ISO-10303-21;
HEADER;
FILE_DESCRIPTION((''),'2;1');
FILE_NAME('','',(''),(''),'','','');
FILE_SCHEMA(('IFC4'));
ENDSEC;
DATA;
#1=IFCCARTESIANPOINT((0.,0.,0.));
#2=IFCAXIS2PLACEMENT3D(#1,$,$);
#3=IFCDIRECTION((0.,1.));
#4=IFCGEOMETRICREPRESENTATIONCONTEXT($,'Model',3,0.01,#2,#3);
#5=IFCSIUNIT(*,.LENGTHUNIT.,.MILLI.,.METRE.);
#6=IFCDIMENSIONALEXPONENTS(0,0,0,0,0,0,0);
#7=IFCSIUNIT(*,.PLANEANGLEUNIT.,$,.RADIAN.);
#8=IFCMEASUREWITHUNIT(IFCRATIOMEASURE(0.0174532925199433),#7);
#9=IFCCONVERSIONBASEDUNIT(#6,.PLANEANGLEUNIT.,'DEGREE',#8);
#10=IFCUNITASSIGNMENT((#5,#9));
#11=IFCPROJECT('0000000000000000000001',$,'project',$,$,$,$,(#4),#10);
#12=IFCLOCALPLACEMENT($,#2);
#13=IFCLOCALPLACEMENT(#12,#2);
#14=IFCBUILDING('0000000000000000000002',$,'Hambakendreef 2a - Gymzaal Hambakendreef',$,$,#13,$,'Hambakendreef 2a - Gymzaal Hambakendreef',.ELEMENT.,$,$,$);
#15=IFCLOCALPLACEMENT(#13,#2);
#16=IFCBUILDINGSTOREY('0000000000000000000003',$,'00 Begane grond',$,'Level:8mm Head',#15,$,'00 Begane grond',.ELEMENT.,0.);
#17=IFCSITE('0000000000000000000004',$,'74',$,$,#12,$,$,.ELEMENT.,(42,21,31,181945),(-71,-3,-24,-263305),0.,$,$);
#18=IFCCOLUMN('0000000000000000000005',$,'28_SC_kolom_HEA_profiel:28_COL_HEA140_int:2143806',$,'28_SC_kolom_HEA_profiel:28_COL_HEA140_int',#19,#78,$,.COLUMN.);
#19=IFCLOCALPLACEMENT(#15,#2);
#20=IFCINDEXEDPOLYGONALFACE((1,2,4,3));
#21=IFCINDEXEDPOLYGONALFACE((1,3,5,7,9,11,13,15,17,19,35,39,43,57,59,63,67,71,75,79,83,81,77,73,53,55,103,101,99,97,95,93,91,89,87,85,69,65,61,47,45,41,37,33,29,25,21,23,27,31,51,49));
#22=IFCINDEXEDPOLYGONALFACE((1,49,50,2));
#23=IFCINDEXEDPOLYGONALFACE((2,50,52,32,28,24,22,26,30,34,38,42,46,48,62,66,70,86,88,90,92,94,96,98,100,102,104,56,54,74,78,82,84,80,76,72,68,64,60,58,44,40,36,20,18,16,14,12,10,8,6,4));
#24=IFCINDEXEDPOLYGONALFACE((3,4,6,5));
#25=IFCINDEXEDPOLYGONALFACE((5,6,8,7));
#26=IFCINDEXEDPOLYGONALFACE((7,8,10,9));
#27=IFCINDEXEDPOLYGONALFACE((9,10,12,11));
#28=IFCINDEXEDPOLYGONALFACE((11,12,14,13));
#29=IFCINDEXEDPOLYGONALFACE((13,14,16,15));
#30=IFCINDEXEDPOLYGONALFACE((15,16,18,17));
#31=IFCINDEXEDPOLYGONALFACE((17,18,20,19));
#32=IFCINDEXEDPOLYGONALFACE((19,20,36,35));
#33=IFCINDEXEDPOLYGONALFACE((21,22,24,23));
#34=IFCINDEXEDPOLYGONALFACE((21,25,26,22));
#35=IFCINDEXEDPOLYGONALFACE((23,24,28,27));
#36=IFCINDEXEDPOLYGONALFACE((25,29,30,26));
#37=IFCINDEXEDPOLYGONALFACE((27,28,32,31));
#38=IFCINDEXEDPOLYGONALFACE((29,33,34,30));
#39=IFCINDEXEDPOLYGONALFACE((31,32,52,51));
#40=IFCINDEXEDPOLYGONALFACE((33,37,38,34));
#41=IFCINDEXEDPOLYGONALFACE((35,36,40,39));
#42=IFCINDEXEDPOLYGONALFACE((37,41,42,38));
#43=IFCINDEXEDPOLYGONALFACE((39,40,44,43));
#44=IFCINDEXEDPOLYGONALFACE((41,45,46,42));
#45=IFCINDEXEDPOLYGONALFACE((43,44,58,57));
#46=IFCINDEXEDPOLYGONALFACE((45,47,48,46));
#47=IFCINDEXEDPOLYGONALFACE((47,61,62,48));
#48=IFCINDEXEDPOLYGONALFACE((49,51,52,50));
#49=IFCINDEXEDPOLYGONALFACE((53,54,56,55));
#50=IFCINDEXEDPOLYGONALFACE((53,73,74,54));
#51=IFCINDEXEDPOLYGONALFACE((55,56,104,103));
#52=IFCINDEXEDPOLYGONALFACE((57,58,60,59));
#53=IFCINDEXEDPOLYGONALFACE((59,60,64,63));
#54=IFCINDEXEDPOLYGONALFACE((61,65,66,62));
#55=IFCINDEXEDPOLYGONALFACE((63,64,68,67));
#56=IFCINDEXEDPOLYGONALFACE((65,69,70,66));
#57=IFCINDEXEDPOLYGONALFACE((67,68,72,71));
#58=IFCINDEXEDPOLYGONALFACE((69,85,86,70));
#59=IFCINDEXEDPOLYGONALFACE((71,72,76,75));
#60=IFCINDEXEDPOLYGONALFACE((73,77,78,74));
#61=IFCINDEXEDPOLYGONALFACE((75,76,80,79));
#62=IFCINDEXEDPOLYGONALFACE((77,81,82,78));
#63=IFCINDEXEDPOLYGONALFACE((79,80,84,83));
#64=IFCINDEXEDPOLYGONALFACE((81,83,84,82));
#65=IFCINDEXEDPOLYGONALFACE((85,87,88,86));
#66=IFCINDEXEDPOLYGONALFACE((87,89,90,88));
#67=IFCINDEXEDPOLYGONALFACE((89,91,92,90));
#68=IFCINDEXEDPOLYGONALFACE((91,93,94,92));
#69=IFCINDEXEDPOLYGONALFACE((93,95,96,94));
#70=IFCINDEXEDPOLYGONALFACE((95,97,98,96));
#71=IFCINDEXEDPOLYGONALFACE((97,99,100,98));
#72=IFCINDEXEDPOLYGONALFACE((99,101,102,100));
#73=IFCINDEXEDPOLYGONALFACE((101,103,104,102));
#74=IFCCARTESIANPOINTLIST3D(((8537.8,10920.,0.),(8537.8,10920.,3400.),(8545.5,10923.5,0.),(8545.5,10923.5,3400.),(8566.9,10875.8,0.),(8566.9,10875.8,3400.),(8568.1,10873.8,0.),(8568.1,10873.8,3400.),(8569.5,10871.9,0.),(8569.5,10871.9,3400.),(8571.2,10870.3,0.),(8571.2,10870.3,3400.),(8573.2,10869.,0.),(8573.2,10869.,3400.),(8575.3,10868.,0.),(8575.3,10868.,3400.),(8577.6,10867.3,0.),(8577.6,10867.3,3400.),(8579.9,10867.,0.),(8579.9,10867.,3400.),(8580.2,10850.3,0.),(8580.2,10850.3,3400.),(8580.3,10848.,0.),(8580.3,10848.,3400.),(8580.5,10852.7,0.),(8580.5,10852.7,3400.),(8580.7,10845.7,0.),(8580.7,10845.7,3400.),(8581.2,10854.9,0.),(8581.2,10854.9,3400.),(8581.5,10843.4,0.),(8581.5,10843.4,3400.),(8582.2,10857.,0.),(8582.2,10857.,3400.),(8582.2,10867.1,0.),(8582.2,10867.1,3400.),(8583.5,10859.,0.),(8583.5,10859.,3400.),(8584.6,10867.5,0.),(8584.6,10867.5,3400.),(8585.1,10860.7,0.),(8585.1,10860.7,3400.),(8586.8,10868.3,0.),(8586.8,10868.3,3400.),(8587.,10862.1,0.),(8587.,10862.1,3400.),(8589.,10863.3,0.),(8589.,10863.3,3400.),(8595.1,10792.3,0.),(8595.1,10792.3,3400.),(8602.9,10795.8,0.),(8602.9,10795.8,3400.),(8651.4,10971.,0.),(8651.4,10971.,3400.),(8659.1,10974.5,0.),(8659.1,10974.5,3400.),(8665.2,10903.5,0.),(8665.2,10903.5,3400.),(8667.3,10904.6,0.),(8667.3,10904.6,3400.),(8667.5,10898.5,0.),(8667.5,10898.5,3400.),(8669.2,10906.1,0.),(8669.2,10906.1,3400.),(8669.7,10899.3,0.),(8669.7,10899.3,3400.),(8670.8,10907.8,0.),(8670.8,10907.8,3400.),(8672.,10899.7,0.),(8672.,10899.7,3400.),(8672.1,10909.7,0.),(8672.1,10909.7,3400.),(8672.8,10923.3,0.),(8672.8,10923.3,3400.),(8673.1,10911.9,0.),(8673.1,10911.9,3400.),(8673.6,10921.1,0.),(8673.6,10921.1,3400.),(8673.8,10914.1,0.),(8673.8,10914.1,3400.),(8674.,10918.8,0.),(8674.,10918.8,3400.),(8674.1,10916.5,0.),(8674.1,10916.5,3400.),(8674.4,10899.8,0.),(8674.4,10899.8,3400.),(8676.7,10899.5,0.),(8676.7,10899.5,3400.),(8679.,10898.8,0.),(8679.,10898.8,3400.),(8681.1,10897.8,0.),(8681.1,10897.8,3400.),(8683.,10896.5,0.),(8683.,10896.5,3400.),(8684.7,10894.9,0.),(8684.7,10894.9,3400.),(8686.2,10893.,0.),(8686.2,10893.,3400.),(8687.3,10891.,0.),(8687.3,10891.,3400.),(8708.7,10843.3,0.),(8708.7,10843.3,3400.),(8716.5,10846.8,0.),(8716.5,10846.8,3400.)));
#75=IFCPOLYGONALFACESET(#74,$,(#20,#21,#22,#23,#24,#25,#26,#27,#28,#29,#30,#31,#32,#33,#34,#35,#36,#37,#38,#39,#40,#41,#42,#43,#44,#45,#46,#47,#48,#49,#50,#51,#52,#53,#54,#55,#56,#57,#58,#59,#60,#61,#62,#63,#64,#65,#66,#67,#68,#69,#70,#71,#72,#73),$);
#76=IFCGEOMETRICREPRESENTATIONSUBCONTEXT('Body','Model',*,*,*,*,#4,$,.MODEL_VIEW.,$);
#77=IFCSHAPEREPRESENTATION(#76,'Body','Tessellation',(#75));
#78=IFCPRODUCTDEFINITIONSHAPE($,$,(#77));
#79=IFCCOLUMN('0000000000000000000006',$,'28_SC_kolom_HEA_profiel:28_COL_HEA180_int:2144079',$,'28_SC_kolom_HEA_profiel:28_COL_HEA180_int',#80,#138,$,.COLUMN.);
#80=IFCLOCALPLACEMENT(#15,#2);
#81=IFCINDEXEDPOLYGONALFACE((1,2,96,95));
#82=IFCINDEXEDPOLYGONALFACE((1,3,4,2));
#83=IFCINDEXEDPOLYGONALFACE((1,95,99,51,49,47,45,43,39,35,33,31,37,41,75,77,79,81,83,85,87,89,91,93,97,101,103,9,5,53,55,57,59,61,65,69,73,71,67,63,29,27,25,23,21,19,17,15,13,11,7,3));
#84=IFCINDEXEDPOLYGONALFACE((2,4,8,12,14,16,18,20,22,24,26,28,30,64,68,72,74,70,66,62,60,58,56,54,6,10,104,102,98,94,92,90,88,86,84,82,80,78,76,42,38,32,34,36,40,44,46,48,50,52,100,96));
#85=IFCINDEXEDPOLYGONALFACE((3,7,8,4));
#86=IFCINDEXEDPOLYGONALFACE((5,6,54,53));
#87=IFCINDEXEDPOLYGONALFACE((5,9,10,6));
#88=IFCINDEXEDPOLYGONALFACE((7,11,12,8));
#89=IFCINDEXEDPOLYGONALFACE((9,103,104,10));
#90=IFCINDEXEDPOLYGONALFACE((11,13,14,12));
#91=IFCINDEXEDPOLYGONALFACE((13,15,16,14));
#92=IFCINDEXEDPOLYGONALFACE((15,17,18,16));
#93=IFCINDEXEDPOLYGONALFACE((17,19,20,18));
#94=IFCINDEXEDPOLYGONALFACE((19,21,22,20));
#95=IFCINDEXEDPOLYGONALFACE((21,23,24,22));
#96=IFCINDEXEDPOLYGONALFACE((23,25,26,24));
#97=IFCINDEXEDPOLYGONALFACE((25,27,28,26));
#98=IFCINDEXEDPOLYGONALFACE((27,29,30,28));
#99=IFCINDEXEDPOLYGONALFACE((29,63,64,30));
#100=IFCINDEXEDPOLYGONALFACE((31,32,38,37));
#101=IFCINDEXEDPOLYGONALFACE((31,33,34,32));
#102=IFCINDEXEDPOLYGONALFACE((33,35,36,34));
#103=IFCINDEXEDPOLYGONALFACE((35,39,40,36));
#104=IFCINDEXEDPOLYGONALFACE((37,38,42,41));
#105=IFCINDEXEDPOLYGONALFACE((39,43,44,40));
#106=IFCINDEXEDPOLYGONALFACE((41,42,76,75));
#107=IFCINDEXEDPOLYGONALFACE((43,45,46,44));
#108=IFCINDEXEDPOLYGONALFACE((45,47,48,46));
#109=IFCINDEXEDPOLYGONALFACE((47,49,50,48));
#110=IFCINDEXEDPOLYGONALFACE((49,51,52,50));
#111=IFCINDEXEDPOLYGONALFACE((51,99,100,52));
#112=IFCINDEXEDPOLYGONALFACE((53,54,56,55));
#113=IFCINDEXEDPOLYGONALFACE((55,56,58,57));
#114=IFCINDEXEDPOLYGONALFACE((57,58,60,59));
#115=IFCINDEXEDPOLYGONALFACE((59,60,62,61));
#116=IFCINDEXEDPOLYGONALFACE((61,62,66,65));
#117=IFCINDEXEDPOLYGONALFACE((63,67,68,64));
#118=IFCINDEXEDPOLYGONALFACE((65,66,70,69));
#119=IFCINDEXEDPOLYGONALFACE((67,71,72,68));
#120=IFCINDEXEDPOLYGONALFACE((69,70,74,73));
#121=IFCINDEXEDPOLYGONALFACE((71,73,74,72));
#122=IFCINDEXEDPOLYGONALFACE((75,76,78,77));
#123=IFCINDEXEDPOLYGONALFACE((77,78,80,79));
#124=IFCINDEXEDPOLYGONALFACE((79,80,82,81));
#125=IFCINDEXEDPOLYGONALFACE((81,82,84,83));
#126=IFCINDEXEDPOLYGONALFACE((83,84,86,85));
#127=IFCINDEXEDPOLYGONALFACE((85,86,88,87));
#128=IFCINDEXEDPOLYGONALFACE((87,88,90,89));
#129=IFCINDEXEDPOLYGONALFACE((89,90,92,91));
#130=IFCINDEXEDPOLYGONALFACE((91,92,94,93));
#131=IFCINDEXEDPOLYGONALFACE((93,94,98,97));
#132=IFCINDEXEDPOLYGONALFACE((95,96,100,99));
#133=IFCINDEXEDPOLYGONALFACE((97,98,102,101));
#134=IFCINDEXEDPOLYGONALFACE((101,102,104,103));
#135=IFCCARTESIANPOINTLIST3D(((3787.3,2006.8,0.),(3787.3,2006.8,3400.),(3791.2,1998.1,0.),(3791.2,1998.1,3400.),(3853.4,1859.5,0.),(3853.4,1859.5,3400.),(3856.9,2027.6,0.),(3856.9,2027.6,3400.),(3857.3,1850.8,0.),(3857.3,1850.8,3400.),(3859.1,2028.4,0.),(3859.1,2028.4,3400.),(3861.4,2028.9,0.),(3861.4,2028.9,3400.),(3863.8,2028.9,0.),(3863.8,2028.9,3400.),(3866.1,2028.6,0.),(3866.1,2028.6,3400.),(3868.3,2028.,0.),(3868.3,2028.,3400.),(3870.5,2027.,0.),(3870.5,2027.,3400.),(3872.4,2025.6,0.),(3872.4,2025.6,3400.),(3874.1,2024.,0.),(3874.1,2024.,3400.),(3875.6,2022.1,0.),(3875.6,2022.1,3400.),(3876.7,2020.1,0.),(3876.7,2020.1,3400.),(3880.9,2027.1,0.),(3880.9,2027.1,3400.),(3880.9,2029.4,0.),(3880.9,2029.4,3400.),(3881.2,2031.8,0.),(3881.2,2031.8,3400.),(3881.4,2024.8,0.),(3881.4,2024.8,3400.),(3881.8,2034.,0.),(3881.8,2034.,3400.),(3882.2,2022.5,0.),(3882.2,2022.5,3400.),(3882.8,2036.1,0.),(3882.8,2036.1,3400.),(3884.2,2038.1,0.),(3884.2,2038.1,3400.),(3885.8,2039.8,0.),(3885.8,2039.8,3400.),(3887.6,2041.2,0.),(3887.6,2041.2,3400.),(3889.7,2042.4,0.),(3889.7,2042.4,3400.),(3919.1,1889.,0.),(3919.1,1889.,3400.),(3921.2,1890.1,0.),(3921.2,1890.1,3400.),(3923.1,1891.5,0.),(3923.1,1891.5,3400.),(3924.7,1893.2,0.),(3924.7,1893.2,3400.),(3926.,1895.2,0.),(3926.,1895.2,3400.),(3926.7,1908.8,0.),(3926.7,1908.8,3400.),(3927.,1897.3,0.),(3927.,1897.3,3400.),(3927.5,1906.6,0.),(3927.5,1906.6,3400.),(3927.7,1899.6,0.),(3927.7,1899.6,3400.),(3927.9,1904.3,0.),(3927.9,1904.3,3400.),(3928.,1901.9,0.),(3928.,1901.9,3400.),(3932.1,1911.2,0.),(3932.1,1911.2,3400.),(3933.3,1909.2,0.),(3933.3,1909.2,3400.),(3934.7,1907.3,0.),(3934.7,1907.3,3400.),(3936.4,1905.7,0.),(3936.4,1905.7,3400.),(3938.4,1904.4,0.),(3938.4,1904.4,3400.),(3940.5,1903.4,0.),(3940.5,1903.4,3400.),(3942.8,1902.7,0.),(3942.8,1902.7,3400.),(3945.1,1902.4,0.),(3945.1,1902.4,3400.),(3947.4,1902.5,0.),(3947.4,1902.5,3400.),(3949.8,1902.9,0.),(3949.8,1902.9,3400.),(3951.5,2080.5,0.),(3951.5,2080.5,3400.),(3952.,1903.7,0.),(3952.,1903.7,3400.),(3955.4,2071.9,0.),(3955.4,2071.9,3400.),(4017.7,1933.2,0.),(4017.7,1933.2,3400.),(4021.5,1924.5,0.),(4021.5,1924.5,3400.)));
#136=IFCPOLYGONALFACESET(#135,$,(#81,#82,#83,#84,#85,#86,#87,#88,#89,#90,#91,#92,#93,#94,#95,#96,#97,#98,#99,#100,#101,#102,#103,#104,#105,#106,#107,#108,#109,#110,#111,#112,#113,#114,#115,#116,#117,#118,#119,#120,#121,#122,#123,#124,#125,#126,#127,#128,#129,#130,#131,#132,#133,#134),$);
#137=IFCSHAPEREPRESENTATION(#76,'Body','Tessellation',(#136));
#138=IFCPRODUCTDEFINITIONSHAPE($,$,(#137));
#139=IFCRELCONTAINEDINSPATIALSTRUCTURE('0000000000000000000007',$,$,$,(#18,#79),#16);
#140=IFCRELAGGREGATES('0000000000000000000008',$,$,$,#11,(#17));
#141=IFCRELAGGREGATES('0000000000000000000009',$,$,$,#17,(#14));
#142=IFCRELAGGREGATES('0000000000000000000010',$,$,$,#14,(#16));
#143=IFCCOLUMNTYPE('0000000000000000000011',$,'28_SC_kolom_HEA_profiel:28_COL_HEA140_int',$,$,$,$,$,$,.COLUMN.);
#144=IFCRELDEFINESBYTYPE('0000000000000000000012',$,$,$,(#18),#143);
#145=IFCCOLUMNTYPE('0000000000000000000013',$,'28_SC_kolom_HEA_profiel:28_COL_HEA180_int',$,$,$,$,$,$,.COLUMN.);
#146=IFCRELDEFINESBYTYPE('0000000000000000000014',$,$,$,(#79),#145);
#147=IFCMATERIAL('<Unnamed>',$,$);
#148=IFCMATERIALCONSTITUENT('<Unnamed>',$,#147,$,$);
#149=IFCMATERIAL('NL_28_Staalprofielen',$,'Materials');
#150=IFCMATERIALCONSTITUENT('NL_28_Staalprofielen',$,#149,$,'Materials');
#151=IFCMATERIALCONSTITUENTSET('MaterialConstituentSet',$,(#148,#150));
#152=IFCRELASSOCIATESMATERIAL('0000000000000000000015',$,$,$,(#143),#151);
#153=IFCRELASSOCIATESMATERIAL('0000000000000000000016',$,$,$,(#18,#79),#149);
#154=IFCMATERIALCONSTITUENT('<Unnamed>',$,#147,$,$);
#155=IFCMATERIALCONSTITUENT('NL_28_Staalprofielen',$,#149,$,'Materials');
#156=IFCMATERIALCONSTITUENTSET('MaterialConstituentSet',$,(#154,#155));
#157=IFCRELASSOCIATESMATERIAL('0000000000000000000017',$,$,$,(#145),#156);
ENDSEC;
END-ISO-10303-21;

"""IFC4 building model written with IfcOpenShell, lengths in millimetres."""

from ifc_helpers import new_model, entity, si_unit, converted_unit, direction, frame, origin, place, context, subcontext, project, spatial, indexed_curve, outline, extrude, source, transform, mapped, material, constituent, constituent_set, type_object, type_shapes, element, save


model = new_model("IFC4")

# Units and contexts
model_context = context("Model", 3, precision=0.01, world=origin(), true_north=direction((0.0, 1.0)))
body_context = subcontext(model_context, "Body", "Model", "MODEL_VIEW")
ifc_project = project(units=[si_unit("LENGTHUNIT", "METRE", prefix="MILLI"), converted_unit("PLANEANGLEUNIT", "DEGREE", entity("IfcRatioMeasure", 0.0174532925199433), si_unit("PLANEANGLEUNIT", "RADIAN"), dimensions=[0, 0, 0, 0, 0, 0, 0])], contexts=[model_context])

# Site, building, storey
site_placement = place(None, origin())
site = spatial("IfcSite", under=ifc_project, at=site_placement, Name="74", CompositionType="ELEMENT", RefLatitude=(42, 21, 31, 181945), RefLongitude=(-71, -3, -24, -263305), RefElevation=0.0)
building_placement = place(site_placement, origin())
building = spatial("IfcBuilding", under=site, at=building_placement, Name="Hambakendreef 2a - Gymzaal Hambakendreef", LongName="Hambakendreef 2a - Gymzaal Hambakendreef", CompositionType="ELEMENT")
storey_placement = place(building_placement, origin())
storey = spatial("IfcBuildingStorey", under=building, at=storey_placement, Name="00 Begane grond", ObjectType="Level:8mm Head", LongName="00 Begane grond", CompositionType="ELEMENT", Elevation=0.0)

# Columns
ifc_material_1 = material(Name="NL_28_Staalprofielen", Category="Materials")
ifc_material_2 = material(Name="<Unnamed>")
ifc_constituent_1 = constituent(ifc_material_2, Name="<Unnamed>")
ifc_constituent_2 = constituent(ifc_material_1, Name="NL_28_Staalprofielen", Category="Materials")
ifc_constituent_set_1 = constituent_set(constituents=[ifc_constituent_1, ifc_constituent_2], Name="MaterialConstituentSet")
column_type_1 = type_object("IfcColumnType", Name="28_SC_kolom_HEA_profiel:28_COL_HEA140_int", PredefinedType="COLUMN", material=ifc_constituent_set_1)
shared_shape_1 = source(origin(), body_context, "Body", "SweptSolid", [
    extrude(outline(indexed_curve([(58.0, -70.0), (66.5, -70.0), (66.5, 70.0), (58.0, 70.0), (58.0, 17.8), (57.8, 15.4), (57.3, 13.1), (56.4, 10.9), (55.1, 8.9), (53.6, 7.1), (51.8, 5.6), (49.8, 4.4), (47.6, 3.5), (45.3, 2.9), (43.0, 2.8), (-43.0, 2.8), (-45.3, 2.9), (-47.6, 3.5), (-49.8, 4.4), (-51.8, 5.6), (-53.6, 7.1), (-55.1, 8.9), (-56.4, 10.9), (-57.3, 13.1), (-57.8, 15.4), (-58.0, 17.7), (-58.0, 70.0), (-66.5, 70.0), (-66.5, -70.0), (-58.0, -70.0), (-58.0, -17.8), (-57.8, -15.4), (-57.3, -13.1), (-56.4, -10.9), (-55.1, -8.9), (-53.6, -7.1), (-51.8, -5.6), (-49.8, -4.4), (-47.6, -3.5), (-45.3, -2.9), (-43.0, -2.7), (43.0, -2.8), (45.3, -2.9), (47.6, -3.5), (49.8, -4.4), (51.8, -5.6), (53.6, -7.1), (55.1, -8.9), (56.4, -10.9), (57.3, -13.1), (57.8, -15.4), (58.0, -17.8), (58.0, -70.0)], self_intersect=False)), frame((0.0, 0.0, 0.0), z_axis=(0.0, 0.0, 1.0), x_axis=(0.0, -1.0, 0.0)), (0.0, 0.0, 1.0), 3400.0),
])
type_shapes(column_type_1, [shared_shape_1])
column_placement = place(storey_placement, frame((8627.1, 10883.4, 0.0), z_axis=(0.0, 0.0, 1.0), x_axis=(0.40959, -0.91227, 0.0)))
element("IfcColumn", 1, at=column_placement, inside=storey, type_object=column_type_1, material=ifc_material_1, Name="28_SC_kolom_HEA_profiel:28_COL_HEA140_int:2143806", ObjectType="28_SC_kolom_HEA_profiel:28_COL_HEA140_int", PredefinedType="COLUMN", context=body_context, shape_type="MappedRepresentation", body=[
    mapped(shared_shape_1, transform((0.0, 0.0, 0.0), scale=1.0)),
])
ifc_constituent_3 = constituent(ifc_material_2, Name="<Unnamed>")
ifc_constituent_4 = constituent(ifc_material_1, Name="NL_28_Staalprofielen", Category="Materials")
ifc_constituent_set_2 = constituent_set(constituents=[ifc_constituent_3, ifc_constituent_4], Name="MaterialConstituentSet")
column_type_2 = type_object("IfcColumnType", Name="28_SC_kolom_HEA_profiel:28_COL_HEA180_int", PredefinedType="COLUMN", material=ifc_constituent_set_2)
shared_shape_2 = source(origin(), body_context, "Body", "SweptSolid", [
    extrude(outline(indexed_curve([(76.0, -90.0), (85.5, -90.0), (85.5, 90.0), (76.0, 90.0), (76.0, 18.0), (75.8, 15.7), (75.3, 13.4), (74.4, 11.2), (73.1, 9.2), (71.6, 7.4), (69.8, 5.9), (67.8, 4.6), (65.6, 3.7), (63.3, 3.2), (61.0, 3.0), (-61.0, 3.0), (-63.3, 3.2), (-65.6, 3.7), (-67.8, 4.6), (-69.8, 5.9), (-71.6, 7.4), (-73.1, 9.2), (-74.4, 11.2), (-75.3, 13.4), (-75.8, 15.7), (-76.0, 18.0), (-76.0, 90.0), (-85.5, 90.0), (-85.5, -90.0), (-76.0, -90.0), (-76.0, -18.0), (-75.8, -15.7), (-75.3, -13.4), (-74.4, -11.2), (-73.1, -9.2), (-71.6, -7.4), (-69.8, -5.9), (-67.8, -4.6), (-65.6, -3.7), (-63.3, -3.2), (-61.0, -3.0), (61.0, -3.0), (63.3, -3.2), (65.6, -3.7), (67.8, -4.6), (69.8, -5.9), (71.6, -7.4), (73.1, -9.2), (74.4, -11.2), (75.3, -13.4), (75.8, -15.7), (76.0, -18.0), (76.0, -90.0)], self_intersect=False)), frame((0.0, 0.0, 0.0), z_axis=(0.0, 0.0, 1.0), x_axis=(0.0, -1.0, 0.0)), (0.0, 0.0, 1.0), 3400.0),
])
type_shapes(column_type_2, [shared_shape_2])
for number, where, z_axis, x_axis, name in (
    (2, (3904.4, 1965.7, 0.0), (0.0, 0.0, 1.0), (0.91227, 0.40959, 0.0), "28_SC_kolom_HEA_profiel:28_COL_HEA180_int:2144079"),
):
    element("IfcColumn", number, at=place(storey_placement, frame(where, z_axis=z_axis, x_axis=x_axis)), inside=storey, type_object=column_type_2, material=ifc_material_1, Name=name, ObjectType="28_SC_kolom_HEA_profiel:28_COL_HEA180_int", PredefinedType="COLUMN", context=body_context, shape_type="MappedRepresentation", body=[
        mapped(shared_shape_2, transform((0.0, 0.0, 0.0), scale=1.0)),
    ])

save(model, "model.ifc")
